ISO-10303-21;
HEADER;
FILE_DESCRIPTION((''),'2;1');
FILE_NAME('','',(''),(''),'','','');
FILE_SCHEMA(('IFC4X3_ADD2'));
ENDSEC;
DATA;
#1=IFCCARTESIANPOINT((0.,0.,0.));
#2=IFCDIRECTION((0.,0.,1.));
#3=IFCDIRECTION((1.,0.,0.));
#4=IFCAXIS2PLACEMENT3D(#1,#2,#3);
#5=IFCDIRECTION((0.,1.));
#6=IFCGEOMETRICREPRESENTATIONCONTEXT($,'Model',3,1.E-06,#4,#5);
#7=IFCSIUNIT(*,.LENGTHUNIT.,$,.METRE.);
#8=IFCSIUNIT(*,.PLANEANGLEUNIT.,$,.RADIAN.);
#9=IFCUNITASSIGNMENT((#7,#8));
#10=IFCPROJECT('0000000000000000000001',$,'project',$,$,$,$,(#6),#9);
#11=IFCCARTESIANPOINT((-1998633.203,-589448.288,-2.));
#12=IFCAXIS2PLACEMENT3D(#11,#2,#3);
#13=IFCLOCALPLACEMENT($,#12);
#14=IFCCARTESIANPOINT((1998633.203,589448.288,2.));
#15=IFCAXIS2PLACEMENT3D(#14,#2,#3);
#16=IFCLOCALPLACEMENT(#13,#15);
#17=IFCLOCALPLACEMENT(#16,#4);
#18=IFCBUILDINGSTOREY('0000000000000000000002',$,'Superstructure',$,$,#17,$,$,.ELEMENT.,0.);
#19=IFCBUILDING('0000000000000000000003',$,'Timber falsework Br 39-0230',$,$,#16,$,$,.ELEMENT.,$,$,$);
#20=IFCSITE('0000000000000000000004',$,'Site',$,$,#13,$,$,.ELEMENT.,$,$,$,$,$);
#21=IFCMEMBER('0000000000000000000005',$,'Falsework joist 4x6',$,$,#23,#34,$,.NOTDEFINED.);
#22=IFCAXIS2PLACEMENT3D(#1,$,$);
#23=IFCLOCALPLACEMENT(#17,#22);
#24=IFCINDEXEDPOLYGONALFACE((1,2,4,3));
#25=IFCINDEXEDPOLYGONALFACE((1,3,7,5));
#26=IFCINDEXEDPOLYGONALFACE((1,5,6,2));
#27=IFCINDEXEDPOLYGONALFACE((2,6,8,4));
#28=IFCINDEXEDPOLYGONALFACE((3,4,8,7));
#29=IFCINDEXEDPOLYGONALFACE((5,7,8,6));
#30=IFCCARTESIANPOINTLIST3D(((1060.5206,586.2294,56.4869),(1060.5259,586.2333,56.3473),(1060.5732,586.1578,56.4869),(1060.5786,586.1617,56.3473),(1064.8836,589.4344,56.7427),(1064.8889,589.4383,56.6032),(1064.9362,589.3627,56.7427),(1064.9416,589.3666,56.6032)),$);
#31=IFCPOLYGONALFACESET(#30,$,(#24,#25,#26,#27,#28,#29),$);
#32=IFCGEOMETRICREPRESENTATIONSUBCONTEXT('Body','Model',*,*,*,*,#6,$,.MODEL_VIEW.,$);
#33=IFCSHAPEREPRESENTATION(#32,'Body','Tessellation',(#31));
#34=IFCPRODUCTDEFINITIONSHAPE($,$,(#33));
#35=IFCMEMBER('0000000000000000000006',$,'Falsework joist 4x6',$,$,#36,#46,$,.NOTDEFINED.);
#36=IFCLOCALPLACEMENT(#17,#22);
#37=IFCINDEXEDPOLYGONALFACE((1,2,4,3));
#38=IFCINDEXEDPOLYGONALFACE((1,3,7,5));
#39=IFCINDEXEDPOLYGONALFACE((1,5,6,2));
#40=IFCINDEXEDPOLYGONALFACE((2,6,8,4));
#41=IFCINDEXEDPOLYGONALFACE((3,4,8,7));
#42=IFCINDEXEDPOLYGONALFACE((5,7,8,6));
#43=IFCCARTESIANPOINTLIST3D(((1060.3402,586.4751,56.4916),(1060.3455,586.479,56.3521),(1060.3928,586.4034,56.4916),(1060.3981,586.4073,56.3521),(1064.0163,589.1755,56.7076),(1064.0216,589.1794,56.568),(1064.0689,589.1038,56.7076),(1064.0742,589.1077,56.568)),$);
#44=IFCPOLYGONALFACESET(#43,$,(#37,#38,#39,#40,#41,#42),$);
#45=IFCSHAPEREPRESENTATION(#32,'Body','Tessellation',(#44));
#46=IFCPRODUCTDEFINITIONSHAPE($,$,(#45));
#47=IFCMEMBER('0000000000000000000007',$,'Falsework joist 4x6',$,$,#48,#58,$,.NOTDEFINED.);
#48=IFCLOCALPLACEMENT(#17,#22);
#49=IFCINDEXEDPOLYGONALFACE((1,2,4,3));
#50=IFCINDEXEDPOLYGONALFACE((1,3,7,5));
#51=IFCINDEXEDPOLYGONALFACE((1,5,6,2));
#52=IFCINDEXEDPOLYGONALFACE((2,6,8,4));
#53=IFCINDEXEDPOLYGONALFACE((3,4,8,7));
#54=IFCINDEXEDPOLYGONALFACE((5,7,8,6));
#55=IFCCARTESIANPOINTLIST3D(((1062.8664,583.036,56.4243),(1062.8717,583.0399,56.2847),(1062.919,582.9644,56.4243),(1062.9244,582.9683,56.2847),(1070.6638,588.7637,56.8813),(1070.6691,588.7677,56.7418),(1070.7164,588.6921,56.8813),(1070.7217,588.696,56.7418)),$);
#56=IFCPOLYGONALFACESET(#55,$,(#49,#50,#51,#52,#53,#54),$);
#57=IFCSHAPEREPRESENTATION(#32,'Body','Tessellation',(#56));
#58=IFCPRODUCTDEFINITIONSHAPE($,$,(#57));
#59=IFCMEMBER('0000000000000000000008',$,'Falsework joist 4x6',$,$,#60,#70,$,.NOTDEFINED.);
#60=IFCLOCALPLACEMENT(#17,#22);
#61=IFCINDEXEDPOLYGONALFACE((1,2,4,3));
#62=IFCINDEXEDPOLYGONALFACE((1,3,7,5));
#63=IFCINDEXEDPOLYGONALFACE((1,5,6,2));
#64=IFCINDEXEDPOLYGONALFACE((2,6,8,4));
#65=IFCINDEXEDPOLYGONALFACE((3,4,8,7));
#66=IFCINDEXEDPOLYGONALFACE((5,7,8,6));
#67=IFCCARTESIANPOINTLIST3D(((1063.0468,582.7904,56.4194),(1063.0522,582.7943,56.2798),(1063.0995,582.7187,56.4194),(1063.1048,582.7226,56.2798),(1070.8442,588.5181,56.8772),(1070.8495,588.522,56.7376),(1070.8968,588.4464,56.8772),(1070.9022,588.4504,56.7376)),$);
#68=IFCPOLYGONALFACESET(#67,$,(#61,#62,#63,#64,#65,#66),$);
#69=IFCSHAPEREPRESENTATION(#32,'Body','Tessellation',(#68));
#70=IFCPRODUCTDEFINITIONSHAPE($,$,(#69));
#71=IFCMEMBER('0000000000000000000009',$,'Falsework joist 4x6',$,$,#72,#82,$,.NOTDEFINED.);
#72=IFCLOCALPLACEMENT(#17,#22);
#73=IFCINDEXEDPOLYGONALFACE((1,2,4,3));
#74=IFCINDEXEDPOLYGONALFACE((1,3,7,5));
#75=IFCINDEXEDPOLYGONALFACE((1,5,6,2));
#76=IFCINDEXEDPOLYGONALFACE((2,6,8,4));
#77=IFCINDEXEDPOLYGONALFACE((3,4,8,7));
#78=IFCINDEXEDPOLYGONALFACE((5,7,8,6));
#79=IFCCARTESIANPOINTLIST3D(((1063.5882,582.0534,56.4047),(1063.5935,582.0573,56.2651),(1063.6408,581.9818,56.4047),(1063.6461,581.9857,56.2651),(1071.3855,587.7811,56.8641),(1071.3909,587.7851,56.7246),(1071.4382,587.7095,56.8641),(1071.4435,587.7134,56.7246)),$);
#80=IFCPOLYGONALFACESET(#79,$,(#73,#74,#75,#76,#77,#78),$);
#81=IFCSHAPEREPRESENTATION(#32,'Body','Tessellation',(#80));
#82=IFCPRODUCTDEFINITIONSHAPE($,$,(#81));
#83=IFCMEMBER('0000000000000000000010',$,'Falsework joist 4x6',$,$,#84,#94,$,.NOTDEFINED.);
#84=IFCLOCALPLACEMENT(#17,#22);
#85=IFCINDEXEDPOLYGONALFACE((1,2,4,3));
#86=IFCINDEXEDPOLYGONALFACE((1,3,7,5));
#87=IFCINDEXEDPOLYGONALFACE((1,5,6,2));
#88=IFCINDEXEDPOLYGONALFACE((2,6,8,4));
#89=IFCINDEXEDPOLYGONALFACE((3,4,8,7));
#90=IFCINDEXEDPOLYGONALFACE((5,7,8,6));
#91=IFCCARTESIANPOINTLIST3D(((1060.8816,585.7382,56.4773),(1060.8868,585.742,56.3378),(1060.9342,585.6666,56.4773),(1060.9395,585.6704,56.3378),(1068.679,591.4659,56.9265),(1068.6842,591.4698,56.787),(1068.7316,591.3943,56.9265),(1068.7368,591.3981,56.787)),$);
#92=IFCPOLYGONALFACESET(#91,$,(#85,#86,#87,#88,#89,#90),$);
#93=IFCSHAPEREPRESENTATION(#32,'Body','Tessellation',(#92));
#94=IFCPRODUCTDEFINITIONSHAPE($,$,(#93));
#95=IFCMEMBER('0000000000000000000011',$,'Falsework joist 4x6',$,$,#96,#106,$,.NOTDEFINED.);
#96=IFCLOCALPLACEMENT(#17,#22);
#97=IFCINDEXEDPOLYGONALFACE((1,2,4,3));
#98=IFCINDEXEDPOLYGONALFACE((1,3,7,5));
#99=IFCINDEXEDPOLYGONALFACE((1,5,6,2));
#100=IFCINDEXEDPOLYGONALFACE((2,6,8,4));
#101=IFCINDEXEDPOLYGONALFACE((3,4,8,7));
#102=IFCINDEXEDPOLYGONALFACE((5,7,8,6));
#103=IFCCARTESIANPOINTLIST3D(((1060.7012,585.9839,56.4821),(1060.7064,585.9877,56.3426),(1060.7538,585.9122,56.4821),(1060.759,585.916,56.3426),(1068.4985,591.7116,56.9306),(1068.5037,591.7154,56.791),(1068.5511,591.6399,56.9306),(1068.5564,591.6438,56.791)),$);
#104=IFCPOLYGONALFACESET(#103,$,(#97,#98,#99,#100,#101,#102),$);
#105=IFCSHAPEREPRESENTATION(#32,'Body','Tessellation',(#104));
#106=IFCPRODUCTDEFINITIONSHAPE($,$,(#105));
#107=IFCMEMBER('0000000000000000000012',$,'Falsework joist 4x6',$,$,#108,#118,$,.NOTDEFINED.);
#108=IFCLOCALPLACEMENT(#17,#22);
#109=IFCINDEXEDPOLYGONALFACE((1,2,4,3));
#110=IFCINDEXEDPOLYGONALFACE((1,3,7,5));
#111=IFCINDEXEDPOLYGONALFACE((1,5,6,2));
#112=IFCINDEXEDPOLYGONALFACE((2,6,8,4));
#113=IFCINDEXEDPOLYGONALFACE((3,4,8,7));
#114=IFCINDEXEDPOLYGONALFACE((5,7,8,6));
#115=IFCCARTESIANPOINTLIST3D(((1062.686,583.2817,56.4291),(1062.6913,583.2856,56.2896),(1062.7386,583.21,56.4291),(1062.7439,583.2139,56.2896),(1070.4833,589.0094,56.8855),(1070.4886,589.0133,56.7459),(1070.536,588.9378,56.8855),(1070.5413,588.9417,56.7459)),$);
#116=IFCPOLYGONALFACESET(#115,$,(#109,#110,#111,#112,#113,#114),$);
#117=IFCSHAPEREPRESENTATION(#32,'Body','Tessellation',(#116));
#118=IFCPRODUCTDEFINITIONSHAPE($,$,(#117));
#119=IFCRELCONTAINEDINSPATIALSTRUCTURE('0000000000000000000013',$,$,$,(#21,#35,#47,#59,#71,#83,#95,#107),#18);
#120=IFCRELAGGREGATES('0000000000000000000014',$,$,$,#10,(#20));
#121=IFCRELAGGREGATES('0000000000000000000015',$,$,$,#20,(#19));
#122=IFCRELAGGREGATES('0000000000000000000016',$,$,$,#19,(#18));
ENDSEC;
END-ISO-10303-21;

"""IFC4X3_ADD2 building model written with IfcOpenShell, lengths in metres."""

from ifc_helpers import new_model, si_unit, direction, frame, frame_2d, origin, origin_with_axes, place, context, subcontext, project, spatial, rectangle, extrude, element, save


model = new_model("IFC4X3_ADD2")

# Units and contexts
model_context = context("Model", 3, precision=1e-06, world=origin_with_axes(), true_north=direction((0.0, 1.0)))
body_context = subcontext(model_context, "Body", "Model", "MODEL_VIEW")
ifc_project = project(units=[si_unit("LENGTHUNIT", "METRE"), si_unit("PLANEANGLEUNIT", "RADIAN")], contexts=[model_context])

# Site, building, storey
site_placement = place(None, frame((-1998633.203, -589448.288, -2.0), z_axis=(0.0, 0.0, 1.0), x_axis=(1.0, 0.0, 0.0)))
site = spatial("IfcSite", under=ifc_project, at=site_placement, Name="Site", CompositionType="ELEMENT")
building_placement = place(site_placement, frame((1998633.203, 589448.288, 2.0), z_axis=(0.0, 0.0, 1.0), x_axis=(1.0, 0.0, 0.0)))
building = spatial("IfcBuilding", under=site, at=building_placement, Name="Timber falsework Br 39-0230", CompositionType="ELEMENT")
storey_placement = place(building_placement, origin_with_axes())
storey = spatial("IfcBuildingStorey", under=building, at=storey_placement, Name="Superstructure", CompositionType="ELEMENT", Elevation=0.0)

# Members
member_1_placement = place(storey_placement, frame((1060.5522, 586.1975, 56.3473), z_axis=(0.80503, 0.591353, 0.047206), x_axis=(-0.592013, 0.805928, 0.0)))
element("IfcMember", 1, at=member_1_placement, inside=storey, Name="Falsework joist 4x6", PredefinedType="NOTDEFINED", context=body_context, shape_type="SweptSolid", body=[
    extrude(rectangle(XDim=0.0889, YDim=0.1397, at=frame_2d((0.0, 0.0698))), origin(), (0.0, 0.0, 1.0), 5.4197),
])
member_2_placement = place(storey_placement, frame((1060.3718, 586.4432, 56.3521), z_axis=(0.805027, 0.591351, 0.047285), x_axis=(-0.592013, 0.805928, 0.0)))
element("IfcMember", 2, at=member_2_placement, inside=storey, Name="Falsework joist 4x6", PredefinedType="NOTDEFINED", context=body_context, shape_type="SweptSolid", body=[
    extrude(rectangle(XDim=0.0889, YDim=0.1397, at=frame_2d((0.0, 0.0698))), origin(), (0.0, 0.0, 1.0), 4.5665),
])
member_3_placement = place(storey_placement, frame((1062.898, 583.0041, 56.2847), z_axis=(0.80503, 0.591354, 0.047192), x_axis=(-0.592013, 0.805928, 0.0)))
element("IfcMember", 3, at=member_3_placement, inside=storey, Name="Falsework joist 4x6", PredefinedType="NOTDEFINED", context=body_context, shape_type="SweptSolid", body=[
    extrude(rectangle(XDim=0.0889, YDim=0.1397, at=frame_2d((0.0, 0.0698))), origin(), (0.0, 0.0, 1.0), 9.6858),
])
member_4_placement = place(storey_placement, frame((1063.0785, 582.7585, 56.2798), z_axis=(0.805027, 0.591351, 0.047267), x_axis=(-0.592013, 0.805928, 0.0)))
element("IfcMember", 4, at=member_4_placement, inside=storey, Name="Falsework joist 4x6", PredefinedType="NOTDEFINED", context=body_context, shape_type="SweptSolid", body=[
    extrude(rectangle(XDim=0.0889, YDim=0.1397, at=frame_2d((0.0, 0.0698))), origin(), (0.0, 0.0, 1.0), 9.6858),
])
member_5_placement = place(storey_placement, frame((1063.6198, 582.0215, 56.2651), z_axis=(0.805021, 0.591347, 0.047436), x_axis=(-0.592013, 0.805928, 0.0)))
element("IfcMember", 5, at=member_5_placement, inside=storey, Name="Falsework joist 4x6", PredefinedType="NOTDEFINED", context=body_context, shape_type="SweptSolid", body=[
    extrude(rectangle(XDim=0.0889, YDim=0.1397, at=frame_2d((0.0, 0.0698))), origin(), (0.0, 0.0, 1.0), 9.6859),
])
member_6_placement = place(storey_placement, frame((1060.9131, 585.7062, 56.3378), z_axis=(0.805061, 0.591376, 0.046377), x_axis=(-0.592013, 0.805928, 0.0)))
element("IfcMember", 6, at=member_6_placement, inside=storey, Name="Falsework joist 4x6", PredefinedType="NOTDEFINED", context=body_context, shape_type="SweptSolid", body=[
    extrude(rectangle(XDim=0.0889, YDim=0.1397, at=frame_2d((0.0, 0.0698))), origin(), (0.0, 0.0, 1.0), 9.6854),
])
member_7_placement = place(storey_placement, frame((1060.7327, 585.9519, 56.3426), z_axis=(0.805064, 0.591378, 0.046304), x_axis=(-0.592013, 0.805928, 0.0)))
element("IfcMember", 7, at=member_7_placement, inside=storey, Name="Falsework joist 4x6", PredefinedType="NOTDEFINED", context=body_context, shape_type="SweptSolid", body=[
    extrude(rectangle(XDim=0.0889, YDim=0.1397, at=frame_2d((0.0, 0.0698))), origin(), (0.0, 0.0, 1.0), 9.6854),
])
member_8_placement = place(storey_placement, frame((1062.7176, 583.2497, 56.2896), z_axis=(0.805033, 0.591356, 0.047118), x_axis=(-0.592013, 0.805928, 0.0)))
element("IfcMember", 8, at=member_8_placement, inside=storey, Name="Falsework joist 4x6", PredefinedType="NOTDEFINED", context=body_context, shape_type="SweptSolid", body=[
    extrude(rectangle(XDim=0.0889, YDim=0.1397, at=frame_2d((0.0, 0.0698))), origin(), (0.0, 0.0, 1.0), 9.6858),
])

save(model, "model.ifc")
